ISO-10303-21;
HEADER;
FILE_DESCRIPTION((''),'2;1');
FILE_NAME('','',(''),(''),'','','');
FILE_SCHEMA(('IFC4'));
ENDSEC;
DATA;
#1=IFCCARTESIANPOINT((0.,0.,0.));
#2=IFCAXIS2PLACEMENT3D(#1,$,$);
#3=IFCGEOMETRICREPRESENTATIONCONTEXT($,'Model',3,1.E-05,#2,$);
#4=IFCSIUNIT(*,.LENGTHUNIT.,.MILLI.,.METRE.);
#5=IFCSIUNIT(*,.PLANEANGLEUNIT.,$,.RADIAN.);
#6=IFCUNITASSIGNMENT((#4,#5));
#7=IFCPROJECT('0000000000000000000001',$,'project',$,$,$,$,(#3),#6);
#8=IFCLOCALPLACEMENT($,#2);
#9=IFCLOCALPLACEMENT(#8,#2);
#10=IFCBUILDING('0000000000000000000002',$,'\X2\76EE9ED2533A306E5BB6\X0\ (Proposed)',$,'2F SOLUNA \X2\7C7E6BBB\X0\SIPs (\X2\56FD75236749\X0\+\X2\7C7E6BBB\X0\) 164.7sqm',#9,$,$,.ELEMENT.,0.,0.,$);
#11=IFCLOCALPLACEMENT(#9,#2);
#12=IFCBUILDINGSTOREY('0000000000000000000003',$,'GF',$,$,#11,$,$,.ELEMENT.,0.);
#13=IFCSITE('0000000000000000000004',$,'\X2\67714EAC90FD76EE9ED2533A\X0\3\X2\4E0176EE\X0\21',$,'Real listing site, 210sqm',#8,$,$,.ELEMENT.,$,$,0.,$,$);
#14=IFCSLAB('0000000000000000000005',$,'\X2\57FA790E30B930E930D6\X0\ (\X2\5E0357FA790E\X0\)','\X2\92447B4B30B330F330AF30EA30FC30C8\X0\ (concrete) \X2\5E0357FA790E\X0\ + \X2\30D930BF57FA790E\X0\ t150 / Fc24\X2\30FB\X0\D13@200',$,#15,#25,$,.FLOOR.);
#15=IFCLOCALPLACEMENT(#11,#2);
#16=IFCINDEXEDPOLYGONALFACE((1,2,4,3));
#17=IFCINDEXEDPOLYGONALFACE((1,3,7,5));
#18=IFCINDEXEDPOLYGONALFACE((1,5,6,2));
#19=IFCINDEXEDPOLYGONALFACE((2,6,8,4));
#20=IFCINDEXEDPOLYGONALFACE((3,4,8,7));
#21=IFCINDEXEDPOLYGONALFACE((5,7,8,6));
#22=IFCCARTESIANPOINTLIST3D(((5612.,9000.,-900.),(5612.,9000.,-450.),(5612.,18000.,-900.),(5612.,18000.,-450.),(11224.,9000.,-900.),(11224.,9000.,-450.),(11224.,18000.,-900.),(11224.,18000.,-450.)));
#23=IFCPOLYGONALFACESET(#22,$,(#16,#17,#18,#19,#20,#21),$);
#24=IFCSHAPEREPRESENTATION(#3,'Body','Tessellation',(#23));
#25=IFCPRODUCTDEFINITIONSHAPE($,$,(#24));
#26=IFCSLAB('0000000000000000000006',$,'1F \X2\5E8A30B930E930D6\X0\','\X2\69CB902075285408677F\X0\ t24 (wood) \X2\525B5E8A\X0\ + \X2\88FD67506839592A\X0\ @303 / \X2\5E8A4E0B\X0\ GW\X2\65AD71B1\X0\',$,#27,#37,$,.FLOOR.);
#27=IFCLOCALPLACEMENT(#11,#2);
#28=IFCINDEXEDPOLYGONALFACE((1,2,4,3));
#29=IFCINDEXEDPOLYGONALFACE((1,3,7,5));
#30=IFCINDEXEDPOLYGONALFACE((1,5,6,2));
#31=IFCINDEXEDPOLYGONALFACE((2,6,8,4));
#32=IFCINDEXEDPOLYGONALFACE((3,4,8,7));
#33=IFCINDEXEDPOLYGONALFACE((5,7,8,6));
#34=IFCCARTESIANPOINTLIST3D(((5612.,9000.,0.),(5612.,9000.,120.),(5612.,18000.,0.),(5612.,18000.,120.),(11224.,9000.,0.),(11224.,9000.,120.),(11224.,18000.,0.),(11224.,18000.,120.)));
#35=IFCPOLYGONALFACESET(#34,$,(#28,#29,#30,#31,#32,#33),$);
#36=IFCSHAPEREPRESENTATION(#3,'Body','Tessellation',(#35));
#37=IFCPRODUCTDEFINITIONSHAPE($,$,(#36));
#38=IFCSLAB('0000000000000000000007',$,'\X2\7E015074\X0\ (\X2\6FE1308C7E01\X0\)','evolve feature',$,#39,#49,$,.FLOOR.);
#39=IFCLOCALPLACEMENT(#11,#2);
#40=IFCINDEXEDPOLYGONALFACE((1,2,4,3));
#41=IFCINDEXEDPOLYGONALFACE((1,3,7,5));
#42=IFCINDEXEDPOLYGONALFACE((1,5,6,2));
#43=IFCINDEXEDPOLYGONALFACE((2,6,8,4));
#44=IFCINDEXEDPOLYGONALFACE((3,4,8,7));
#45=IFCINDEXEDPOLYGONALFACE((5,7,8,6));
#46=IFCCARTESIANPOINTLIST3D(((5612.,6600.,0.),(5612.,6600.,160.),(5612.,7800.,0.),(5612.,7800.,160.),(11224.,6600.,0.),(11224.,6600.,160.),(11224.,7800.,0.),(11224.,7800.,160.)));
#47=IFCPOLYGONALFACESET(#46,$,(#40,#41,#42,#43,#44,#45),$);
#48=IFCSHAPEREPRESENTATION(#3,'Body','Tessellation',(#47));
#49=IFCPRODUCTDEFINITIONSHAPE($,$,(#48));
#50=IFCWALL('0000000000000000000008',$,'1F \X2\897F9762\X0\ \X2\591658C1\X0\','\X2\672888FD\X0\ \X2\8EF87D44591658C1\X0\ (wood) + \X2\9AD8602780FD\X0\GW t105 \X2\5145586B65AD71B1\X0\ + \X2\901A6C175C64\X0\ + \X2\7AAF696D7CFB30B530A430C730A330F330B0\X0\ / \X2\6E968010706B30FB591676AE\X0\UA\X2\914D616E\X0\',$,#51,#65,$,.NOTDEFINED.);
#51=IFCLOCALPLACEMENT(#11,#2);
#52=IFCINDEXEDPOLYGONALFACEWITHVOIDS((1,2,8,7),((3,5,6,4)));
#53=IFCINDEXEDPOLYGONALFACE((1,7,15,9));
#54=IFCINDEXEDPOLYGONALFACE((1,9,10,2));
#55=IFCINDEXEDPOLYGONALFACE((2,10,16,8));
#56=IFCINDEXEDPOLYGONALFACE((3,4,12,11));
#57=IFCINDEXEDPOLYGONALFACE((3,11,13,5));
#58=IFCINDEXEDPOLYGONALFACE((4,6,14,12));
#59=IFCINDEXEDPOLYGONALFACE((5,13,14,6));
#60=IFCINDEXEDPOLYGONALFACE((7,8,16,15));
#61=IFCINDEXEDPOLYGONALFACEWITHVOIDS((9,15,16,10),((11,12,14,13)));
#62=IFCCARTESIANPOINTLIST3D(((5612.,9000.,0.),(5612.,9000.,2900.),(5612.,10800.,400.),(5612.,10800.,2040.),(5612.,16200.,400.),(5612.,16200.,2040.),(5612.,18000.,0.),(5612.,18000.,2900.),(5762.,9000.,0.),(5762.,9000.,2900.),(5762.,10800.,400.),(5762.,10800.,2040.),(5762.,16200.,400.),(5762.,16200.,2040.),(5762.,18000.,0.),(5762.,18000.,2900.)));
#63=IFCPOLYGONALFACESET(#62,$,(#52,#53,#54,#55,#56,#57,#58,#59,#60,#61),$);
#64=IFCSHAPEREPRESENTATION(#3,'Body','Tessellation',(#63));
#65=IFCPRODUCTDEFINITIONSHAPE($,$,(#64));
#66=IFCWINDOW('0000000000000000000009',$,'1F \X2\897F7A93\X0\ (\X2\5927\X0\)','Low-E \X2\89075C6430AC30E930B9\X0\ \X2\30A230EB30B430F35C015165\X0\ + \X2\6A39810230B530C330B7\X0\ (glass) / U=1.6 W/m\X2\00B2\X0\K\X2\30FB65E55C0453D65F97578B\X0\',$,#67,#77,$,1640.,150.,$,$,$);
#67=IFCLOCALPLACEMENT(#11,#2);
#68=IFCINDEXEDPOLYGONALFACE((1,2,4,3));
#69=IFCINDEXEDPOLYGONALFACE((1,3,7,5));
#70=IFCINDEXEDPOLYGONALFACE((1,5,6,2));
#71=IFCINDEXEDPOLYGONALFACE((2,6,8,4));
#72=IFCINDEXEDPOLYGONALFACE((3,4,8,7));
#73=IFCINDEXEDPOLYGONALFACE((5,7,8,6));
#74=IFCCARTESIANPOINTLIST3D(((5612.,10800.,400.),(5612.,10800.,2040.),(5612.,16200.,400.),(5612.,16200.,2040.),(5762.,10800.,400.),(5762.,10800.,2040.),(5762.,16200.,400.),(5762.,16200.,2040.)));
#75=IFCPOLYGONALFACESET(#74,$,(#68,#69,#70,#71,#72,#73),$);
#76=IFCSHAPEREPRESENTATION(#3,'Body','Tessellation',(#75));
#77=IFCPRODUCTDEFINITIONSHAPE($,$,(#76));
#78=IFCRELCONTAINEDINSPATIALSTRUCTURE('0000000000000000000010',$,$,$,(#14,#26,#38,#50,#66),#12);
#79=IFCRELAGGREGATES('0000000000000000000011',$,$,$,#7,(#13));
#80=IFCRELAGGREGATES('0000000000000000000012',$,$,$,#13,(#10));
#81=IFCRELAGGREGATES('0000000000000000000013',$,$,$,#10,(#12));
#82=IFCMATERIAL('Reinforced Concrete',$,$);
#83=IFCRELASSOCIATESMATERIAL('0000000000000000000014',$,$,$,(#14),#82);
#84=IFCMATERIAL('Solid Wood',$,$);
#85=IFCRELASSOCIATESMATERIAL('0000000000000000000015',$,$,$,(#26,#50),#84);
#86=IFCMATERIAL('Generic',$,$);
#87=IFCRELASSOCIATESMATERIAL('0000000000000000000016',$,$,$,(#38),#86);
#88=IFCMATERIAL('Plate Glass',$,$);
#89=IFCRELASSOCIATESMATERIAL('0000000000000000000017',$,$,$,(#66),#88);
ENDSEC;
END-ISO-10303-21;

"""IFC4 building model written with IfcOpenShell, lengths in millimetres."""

from ifc_helpers import new_model, si_unit, frame, frame_2d, origin, place, context, project, spatial, rectangle, extrude, material, element, fill, save


model = new_model("IFC4")

# Units and contexts
model_context = context("Model", 3, precision=1e-05, world=origin())
ifc_project = project(units=[si_unit("LENGTHUNIT", "METRE", prefix="MILLI"), si_unit("PLANEANGLEUNIT", "RADIAN")], contexts=[model_context])

# Site, building, storey
site_placement = place(None, origin())
site = spatial("IfcSite", under=ifc_project, at=site_placement, Name="東京都目黒区3丁目21", ObjectType="Real listing site, 210sqm", CompositionType="ELEMENT", RefElevation=0.0)
building_placement = place(site_placement, origin())
building = spatial("IfcBuilding", under=site, at=building_placement, Name="目黒区の家 (Proposed)", ObjectType="2F SOLUNA 籾殻SIPs (国産杉+籾殻) 164.7sqm", CompositionType="ELEMENT", ElevationOfRefHeight=0.0, ElevationOfTerrain=0.0)
storey_placement = place(building_placement, origin())
storey = spatial("IfcBuildingStorey", under=building, at=storey_placement, Name="GF", CompositionType="ELEMENT", Elevation=0.0)

# Slabs
ifc_material_1 = material(Name="Reinforced Concrete")
slab_1_placement = place(storey_placement, frame((2806.0, 4500.0, -450.0)))
element("IfcSlab", 1, at=slab_1_placement, inside=storey, material=ifc_material_1, Name="基礎スラブ (布基礎)", Description="鉄筋コンクリート (concrete) 布基礎 + ベタ基礎 t150 / Fc24・D13@200", PredefinedType="FLOOR", context=model_context, shape_type="SweptSolid", body=[
    extrude(rectangle(XDim=5612.0, YDim=9000.0, at=frame_2d((2806.0, 4500.0))), frame((2806.0, 4500.0, -450.0)), (0.0, 0.0, 1.0), 450.0),
])
ifc_material_2 = material(Name="Solid Wood")
slab_2_placement = place(storey_placement, frame((2806.0, 4500.0, 0.0)))
element("IfcSlab", 2, at=slab_2_placement, inside=storey, material=ifc_material_2, Name="1F 床スラブ", Description="構造用合板 t24 (wood) 剛床 + 製材根太 @303 / 床下 GW断熱", PredefinedType="FLOOR", context=model_context, shape_type="SweptSolid", body=[
    extrude(rectangle(XDim=5612.0, YDim=9000.0, at=frame_2d((2806.0, 4500.0))), frame((2806.0, 4500.0, 0.0)), (0.0, 0.0, 1.0), 120.0),
])
ifc_material_3 = material(Name="Generic")
slab_3_placement = place(storey_placement, frame((2806.0, 3300.0, 0.0)))
element("IfcSlab", 3, at=slab_3_placement, inside=storey, material=ifc_material_3, Name="縁側 (濡れ縁)", Description="evolve feature", PredefinedType="FLOOR", context=model_context, shape_type="SweptSolid", body=[
    extrude(rectangle(XDim=5612.0, YDim=1200.0, at=frame_2d((2806.0, 600.0))), frame((2806.0, 3300.0, 0.0)), (0.0, 0.0, 1.0), 160.0),
])

# Shared definitions
ifc_material_4 = material(Name="Plate Glass")

# Wall, opening, window
wall_1_placement = place(storey_placement, frame((2806.0, 4500.0, 0.0)))
wall_1 = element("IfcWall", 4, at=wall_1_placement, inside=storey, material=ifc_material_2, Name="1F 西面 外壁", Description="木製 軸組外壁 (wood) + 高性能GW t105 充填断熱 + 通気層 + 窯業系サイディング / 準耐火・外皮UA配慮", PredefinedType="NOTDEFINED", context=model_context, shape_type="SweptSolid", body=[
    extrude(rectangle(XDim=150.0, YDim=9000.0, at=frame_2d((75.0, 4500.0))), frame((2806.0, 4500.0, 0.0)), (0.0, 0.0, 1.0), 2900.0),
])
opening_1_placement = place(storey_placement, frame((2806.0, 5400.0, 200.0)))
opening_1 = element("IfcOpeningElement", 5, at=opening_1_placement, cuts=wall_1, PredefinedType="NOTDEFINED", context=model_context, shape_type="SweptSolid", body=[
    extrude(rectangle(XDim=150.0, YDim=5400.0, at=frame_2d((75.0, 2700.0))), frame((2806.0, 5400.0, 200.0)), (0.0, 0.0, 1.0), 1640.0),
])
window_1_placement = place(storey_placement, frame((2806.0, 5400.0, 200.0)))
window_1 = element("IfcWindow", 6, at=window_1_placement, inside=storey, material=ifc_material_4, Name="1F 西窓 (大)", Description="Low-E 複層ガラス アルゴン封入 + 樹脂サッシ (glass) / U=1.6 W/m²K・日射取得型", OverallHeight=1640.0, OverallWidth=150.0, context=model_context, shape_type="SweptSolid", body=[
    extrude(rectangle(XDim=150.0, YDim=5400.0, at=frame_2d((75.0, 2700.0))), frame((2806.0, 5400.0, 200.0)), (0.0, 0.0, 1.0), 1640.0),
])
fill(opening_1, window_1)

save(model, "model.ifc")
